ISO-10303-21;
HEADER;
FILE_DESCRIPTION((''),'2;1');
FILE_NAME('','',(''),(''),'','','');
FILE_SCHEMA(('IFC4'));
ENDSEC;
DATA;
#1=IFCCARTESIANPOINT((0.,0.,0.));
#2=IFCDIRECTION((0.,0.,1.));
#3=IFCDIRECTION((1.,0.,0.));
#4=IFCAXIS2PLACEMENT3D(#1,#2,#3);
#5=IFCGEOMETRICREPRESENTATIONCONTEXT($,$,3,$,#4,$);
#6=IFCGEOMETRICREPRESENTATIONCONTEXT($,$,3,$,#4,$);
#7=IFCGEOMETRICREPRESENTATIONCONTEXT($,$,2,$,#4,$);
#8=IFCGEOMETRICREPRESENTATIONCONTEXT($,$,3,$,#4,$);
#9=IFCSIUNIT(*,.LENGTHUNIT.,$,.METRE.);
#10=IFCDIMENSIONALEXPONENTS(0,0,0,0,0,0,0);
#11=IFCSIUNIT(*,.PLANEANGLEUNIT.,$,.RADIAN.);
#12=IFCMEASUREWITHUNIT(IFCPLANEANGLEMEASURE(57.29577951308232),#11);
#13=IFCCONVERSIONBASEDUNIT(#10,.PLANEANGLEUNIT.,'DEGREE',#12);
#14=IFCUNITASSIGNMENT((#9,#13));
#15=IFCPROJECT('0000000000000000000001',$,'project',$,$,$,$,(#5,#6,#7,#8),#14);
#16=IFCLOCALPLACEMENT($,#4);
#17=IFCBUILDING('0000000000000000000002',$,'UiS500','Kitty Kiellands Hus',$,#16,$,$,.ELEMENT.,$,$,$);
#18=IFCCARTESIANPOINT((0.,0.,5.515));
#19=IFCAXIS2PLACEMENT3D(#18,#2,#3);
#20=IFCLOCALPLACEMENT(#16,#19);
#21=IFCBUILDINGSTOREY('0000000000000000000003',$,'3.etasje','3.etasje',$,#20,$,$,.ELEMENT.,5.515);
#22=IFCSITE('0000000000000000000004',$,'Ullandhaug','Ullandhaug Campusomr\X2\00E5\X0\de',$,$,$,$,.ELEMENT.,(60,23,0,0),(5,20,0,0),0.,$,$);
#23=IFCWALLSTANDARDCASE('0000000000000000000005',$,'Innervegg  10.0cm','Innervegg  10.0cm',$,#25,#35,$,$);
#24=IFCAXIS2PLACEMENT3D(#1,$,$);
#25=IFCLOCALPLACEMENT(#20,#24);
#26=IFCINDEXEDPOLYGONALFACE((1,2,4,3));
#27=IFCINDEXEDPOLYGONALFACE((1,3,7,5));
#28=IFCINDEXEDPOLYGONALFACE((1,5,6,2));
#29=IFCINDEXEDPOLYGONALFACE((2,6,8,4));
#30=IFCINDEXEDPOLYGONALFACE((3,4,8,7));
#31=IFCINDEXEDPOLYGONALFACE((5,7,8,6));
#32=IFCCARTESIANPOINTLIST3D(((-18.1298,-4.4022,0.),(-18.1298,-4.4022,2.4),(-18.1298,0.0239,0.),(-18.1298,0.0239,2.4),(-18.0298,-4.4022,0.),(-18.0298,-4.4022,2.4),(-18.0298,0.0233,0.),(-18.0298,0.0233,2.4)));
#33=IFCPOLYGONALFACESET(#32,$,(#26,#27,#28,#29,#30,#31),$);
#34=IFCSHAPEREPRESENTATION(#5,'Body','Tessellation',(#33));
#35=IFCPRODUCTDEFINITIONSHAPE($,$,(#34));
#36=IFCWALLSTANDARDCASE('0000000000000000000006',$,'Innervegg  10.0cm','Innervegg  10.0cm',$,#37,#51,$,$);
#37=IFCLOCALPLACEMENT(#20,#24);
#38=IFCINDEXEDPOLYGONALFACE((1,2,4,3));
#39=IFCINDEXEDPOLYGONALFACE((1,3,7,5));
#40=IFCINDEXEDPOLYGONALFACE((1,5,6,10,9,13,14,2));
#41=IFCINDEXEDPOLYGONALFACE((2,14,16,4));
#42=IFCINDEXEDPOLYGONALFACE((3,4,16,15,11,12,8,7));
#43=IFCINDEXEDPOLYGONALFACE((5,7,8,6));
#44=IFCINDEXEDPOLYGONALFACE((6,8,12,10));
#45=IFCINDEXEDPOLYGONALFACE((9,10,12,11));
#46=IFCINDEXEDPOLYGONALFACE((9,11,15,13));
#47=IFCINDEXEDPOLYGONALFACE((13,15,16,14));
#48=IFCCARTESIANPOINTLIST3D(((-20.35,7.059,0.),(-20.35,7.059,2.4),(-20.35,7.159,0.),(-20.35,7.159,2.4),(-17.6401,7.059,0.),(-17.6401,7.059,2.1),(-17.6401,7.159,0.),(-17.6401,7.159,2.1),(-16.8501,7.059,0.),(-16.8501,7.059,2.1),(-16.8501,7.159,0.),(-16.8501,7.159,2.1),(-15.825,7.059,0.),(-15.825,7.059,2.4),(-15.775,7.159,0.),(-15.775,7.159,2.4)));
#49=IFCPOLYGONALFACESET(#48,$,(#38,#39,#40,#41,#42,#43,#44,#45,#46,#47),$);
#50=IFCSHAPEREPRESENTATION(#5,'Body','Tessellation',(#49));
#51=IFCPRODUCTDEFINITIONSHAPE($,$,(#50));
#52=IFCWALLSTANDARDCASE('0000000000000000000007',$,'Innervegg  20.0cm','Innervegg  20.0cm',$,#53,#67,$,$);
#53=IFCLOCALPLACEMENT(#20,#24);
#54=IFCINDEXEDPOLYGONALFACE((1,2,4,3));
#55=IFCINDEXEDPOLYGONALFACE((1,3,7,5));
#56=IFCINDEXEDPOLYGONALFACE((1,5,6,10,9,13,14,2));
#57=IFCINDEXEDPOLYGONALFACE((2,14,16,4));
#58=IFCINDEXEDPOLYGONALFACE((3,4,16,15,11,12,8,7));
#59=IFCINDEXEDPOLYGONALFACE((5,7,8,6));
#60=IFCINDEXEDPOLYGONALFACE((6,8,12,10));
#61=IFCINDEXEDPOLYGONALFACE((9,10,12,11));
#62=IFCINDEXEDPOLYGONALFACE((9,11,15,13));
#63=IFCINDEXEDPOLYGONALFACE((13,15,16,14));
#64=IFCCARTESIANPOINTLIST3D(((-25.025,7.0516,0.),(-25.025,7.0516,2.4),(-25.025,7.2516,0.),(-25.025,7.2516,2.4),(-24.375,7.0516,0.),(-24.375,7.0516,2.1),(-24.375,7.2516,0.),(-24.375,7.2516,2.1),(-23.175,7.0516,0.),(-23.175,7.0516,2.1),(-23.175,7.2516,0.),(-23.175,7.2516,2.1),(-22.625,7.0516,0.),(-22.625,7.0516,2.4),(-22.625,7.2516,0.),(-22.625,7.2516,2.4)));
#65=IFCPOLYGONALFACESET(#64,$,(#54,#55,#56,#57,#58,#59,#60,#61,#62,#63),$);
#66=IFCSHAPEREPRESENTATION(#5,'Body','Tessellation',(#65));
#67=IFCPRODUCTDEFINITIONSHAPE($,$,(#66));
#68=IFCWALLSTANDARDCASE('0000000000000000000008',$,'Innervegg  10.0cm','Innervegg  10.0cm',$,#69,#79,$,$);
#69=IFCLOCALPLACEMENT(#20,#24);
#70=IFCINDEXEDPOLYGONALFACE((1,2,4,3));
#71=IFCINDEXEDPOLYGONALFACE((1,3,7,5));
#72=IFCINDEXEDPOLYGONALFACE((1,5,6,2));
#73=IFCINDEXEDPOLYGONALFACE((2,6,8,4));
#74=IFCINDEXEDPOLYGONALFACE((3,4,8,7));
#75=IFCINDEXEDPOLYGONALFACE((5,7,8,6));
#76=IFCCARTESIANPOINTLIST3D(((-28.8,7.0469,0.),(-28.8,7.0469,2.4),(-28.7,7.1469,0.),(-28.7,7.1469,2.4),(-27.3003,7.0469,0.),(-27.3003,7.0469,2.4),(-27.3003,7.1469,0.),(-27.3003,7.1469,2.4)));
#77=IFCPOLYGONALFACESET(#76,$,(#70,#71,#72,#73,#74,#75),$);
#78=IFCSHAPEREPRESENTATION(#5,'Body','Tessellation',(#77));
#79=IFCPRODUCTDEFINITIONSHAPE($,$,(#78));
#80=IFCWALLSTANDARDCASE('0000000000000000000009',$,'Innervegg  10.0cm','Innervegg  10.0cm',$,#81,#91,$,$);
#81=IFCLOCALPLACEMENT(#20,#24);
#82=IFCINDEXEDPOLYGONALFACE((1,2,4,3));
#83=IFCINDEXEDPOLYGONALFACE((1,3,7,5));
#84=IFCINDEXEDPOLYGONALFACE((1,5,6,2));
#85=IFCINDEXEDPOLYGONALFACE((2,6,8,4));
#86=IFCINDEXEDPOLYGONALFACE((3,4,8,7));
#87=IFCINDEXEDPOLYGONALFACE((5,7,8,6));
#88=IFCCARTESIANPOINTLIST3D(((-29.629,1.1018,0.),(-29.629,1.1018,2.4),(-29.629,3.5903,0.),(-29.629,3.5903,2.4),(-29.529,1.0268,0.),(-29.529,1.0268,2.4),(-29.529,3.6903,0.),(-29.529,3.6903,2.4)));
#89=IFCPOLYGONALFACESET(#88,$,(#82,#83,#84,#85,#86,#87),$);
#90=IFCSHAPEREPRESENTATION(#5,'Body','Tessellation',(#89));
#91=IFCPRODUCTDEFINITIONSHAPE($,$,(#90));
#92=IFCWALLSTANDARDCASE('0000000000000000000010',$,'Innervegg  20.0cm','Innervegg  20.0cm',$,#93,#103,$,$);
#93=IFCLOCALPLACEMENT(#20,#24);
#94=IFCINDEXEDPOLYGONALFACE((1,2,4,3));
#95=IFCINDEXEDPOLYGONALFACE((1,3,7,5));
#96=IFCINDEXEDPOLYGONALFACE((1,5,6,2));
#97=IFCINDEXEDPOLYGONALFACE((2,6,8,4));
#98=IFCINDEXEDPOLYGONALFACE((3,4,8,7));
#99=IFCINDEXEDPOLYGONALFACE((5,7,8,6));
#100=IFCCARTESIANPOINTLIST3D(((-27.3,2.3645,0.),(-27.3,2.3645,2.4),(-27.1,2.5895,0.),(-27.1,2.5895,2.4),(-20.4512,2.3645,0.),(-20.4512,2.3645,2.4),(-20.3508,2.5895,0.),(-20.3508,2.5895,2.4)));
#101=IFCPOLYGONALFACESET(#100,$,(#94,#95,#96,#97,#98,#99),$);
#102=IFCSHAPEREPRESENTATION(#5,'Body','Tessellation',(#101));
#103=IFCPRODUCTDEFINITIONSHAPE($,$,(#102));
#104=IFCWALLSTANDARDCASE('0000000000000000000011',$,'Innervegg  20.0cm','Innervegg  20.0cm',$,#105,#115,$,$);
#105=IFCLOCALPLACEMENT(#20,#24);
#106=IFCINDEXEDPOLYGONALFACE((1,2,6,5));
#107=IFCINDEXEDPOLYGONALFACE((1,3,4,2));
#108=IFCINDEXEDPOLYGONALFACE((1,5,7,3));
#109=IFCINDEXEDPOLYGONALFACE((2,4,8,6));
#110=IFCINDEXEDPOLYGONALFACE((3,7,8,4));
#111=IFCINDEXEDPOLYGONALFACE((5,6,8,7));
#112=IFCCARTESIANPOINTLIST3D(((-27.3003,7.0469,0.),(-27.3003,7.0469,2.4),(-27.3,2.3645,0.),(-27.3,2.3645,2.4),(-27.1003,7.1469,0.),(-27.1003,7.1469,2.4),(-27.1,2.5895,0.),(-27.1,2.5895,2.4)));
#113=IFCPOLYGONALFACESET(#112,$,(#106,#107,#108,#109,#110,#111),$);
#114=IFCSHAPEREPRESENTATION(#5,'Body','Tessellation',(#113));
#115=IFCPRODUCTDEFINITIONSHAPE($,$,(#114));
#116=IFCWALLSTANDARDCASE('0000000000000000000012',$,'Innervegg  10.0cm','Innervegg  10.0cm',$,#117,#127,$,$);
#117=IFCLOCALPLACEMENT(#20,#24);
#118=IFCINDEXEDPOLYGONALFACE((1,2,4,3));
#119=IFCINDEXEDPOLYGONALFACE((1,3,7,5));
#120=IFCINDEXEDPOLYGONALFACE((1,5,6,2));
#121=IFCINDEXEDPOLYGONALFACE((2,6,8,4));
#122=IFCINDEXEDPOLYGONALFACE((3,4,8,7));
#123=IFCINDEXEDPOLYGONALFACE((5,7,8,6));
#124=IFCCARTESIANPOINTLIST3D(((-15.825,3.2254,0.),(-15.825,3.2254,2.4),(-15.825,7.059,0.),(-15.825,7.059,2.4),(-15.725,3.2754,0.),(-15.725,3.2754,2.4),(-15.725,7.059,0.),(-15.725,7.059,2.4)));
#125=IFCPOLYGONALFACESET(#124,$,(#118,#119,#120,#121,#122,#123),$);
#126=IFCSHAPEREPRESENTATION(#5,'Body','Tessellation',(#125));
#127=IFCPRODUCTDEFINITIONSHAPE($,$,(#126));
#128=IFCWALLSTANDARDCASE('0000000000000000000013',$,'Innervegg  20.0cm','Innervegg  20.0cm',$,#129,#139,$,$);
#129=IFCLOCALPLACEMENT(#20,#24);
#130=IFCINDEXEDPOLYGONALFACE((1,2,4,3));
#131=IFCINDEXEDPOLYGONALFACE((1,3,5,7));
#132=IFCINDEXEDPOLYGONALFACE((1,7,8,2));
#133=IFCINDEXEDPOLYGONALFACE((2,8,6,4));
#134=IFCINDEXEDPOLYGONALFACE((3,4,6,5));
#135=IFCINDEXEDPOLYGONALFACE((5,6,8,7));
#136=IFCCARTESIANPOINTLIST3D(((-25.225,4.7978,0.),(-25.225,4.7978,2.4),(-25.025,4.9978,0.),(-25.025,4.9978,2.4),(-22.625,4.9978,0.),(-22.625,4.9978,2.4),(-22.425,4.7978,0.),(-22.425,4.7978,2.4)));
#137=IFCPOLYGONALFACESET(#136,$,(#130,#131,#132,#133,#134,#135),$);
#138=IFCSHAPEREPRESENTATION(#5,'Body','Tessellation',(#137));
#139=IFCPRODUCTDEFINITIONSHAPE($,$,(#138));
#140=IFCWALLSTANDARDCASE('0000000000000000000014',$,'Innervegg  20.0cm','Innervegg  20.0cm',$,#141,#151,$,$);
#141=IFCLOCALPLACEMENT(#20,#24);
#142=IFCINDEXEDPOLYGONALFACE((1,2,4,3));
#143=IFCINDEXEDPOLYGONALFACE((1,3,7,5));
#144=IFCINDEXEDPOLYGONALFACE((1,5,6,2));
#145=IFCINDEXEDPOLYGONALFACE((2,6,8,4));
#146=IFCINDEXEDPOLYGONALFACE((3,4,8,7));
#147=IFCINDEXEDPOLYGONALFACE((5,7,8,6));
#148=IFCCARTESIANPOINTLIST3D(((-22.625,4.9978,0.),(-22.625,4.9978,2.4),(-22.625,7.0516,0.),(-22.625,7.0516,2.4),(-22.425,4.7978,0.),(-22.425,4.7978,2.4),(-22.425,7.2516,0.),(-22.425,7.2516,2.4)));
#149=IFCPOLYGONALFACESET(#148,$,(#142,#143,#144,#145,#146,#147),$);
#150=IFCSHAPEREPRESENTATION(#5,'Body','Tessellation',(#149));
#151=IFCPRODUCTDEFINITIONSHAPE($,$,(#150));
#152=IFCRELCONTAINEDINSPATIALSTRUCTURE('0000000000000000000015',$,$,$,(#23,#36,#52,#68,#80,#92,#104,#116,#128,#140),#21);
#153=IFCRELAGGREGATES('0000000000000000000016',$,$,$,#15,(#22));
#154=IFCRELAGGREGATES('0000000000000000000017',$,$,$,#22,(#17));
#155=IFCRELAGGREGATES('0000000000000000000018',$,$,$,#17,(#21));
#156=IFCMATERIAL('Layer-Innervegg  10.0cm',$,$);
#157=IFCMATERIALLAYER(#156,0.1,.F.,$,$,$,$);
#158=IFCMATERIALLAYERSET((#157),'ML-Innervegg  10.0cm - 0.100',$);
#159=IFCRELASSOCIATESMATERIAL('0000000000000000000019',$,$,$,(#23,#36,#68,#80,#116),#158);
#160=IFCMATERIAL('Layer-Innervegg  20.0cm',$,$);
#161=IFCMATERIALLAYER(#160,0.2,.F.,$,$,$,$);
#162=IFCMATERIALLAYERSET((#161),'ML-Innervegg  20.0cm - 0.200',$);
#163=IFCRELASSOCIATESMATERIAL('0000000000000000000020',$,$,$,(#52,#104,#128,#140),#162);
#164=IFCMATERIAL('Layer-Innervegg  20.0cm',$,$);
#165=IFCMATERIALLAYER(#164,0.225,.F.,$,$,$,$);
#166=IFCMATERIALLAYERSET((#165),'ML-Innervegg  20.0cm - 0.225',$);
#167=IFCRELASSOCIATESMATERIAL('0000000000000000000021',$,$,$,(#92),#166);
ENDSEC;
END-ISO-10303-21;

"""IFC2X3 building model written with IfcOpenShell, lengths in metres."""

from ifc_helpers import new_model, entity, si_unit, converted_unit, frame, origin_with_axes, place, context, project, spatial, polyline, outline, extrude, material, layer, layer_set, layer_usage, element, save


model = new_model("IFC2X3")

# Units and contexts
context_of_model_1 = context(None, 3, world=origin_with_axes())
context_of_model_2 = context(None, 3, world=origin_with_axes())
context_of_model_3 = context(None, 2, world=origin_with_axes())
context_of_model_4 = context(None, 3, world=origin_with_axes())
ifc_project = project(units=[si_unit("LENGTHUNIT", "METRE"), converted_unit("PLANEANGLEUNIT", "DEGREE", entity("IfcPlaneAngleMeasure", 57.29577951308232), si_unit("PLANEANGLEUNIT", "RADIAN"), dimensions=[0, 0, 0, 0, 0, 0, 0])], contexts=[context_of_model_1, context_of_model_2, context_of_model_3, context_of_model_4])

# Site, building, storey
site = spatial("IfcSite", under=ifc_project, Name="Ullandhaug", Description="Ullandhaug Campusområde", CompositionType="ELEMENT", RefLatitude=(60, 23, 0, 0), RefLongitude=(5, 20, 0, 0), RefElevation=0.0)
building_placement = place(None, origin_with_axes())
building = spatial("IfcBuilding", under=site, at=building_placement, Name="UiS500", Description="Kitty Kiellands Hus", CompositionType="ELEMENT")
storey_placement = place(building_placement, frame((0.0, 0.0, 5.515), z_axis=(0.0, 0.0, 1.0), x_axis=(1.0, 0.0, 0.0)))
storey = spatial("IfcBuildingStorey", under=building, at=storey_placement, Name="3.etasje", Description="3.etasje", CompositionType="ELEMENT", Elevation=5.515)

# Shared definitions
ifc_material_1 = material(Name="Layer-Innervegg  10.0cm")
ifc_layer_1 = layer(ifc_material_1, 0.1, ventilated=False)
ifc_layer_set_1 = layer_set([ifc_layer_1], Name="ML-Innervegg  10.0cm - 0.100")
ifc_layer_usage_1 = layer_usage(ifc_layer_set_1, "AXIS2", "POSITIVE", 0.0)

# Wall
wall_1_placement = place(storey_placement, frame((-18.1298, 0.0239, 0.0), z_axis=(0.0, 0.0, 1.0), x_axis=(0.0, -1.0, 0.0)))
element("IfcWallStandardCase", 1, at=wall_1_placement, inside=storey, material=ifc_layer_usage_1, Name="Innervegg  10.0cm", Description="Innervegg  10.0cm", context=context_of_model_1, shape_type="SweptSolid", body=[
    extrude(outline(polyline([(0.0, 0.0), (4.4262, 0.0), (4.4262, 0.1), (0.0006, 0.1), (0.0, 0.0)])), frame((0.0, 0.0, 0.0), z_axis=(0.0, 0.0, 1.0), x_axis=(1.0, 0.0, 0.0)), (0.0, 0.0, 1.0), 2.4),
])

# Walls, openings
wall_2_placement = place(storey_placement, frame((-20.35, 7.059, 0.0), z_axis=(0.0, 0.0, 1.0), x_axis=(1.0, 0.0, 0.0)))
wall_2 = element("IfcWallStandardCase", 2, at=wall_2_placement, inside=storey, material=ifc_layer_usage_1, Name="Innervegg  10.0cm", Description="Innervegg  10.0cm", context=context_of_model_1, shape_type="SweptSolid", body=[
    extrude(outline(polyline([(0.0, 0.0), (4.525, 0.0), (4.575, 0.1), (0.0, 0.1), (0.0, 0.0)])), origin_with_axes(), (0.0, 0.0, 1.0), 2.4),
])
opening_1_placement = place(wall_2_placement, frame((2.7099, 0.1, 0.0), z_axis=(0.0, 0.0, 1.0), x_axis=(1.0, 0.0, 0.0)))
element("IfcOpeningElement", 3, at=opening_1_placement, cuts=wall_2, context=context_of_model_1, shape_type="SweptSolid", body=[
    extrude(outline(polyline([(0.0, 0.0), (2.1, 0.0), (2.1, 0.79), (0.0, 0.79), (0.0, 0.0)])), frame((0.0, 0.0, 0.0), z_axis=(0.0, 1.0, 0.0), x_axis=(0.0, 0.0, 1.0)), (0.0, 0.0, -1.0), 0.1),
])
ifc_material_2 = material(Name="Layer-Innervegg  20.0cm")
ifc_layer_2 = layer(ifc_material_2, 0.2, ventilated=False)
ifc_layer_set_2 = layer_set([ifc_layer_2], Name="ML-Innervegg  20.0cm - 0.200")
ifc_layer_usage_2 = layer_usage(ifc_layer_set_2, "AXIS2", "POSITIVE", 0.0)
wall_3_placement = place(storey_placement, frame((-25.025, 7.0516, 0.0), z_axis=(0.0, 0.0, 1.0), x_axis=(1.0, 0.0, 0.0)))
wall_3 = element("IfcWallStandardCase", 4, at=wall_3_placement, inside=storey, material=ifc_layer_usage_2, Name="Innervegg  20.0cm", Description="Innervegg  20.0cm", context=context_of_model_1, shape_type="SweptSolid", body=[
    extrude(outline(polyline([(0.0, 0.0), (2.4, 0.0), (2.4, 0.2), (0.0, 0.2), (0.0, 0.0)])), origin_with_axes(), (0.0, 0.0, 1.0), 2.4),
])
opening_2_placement = place(wall_3_placement, frame((0.65, 0.2, 0.0), z_axis=(0.0, 0.0, 1.0), x_axis=(1.0, 0.0, 0.0)))
element("IfcOpeningElement", 5, at=opening_2_placement, cuts=wall_3, context=context_of_model_1, shape_type="SweptSolid", body=[
    extrude(outline(polyline([(0.0, 0.0), (2.1, 0.0), (2.1, 1.2), (0.0, 1.2), (0.0, 0.0)])), frame((0.0, 0.0, 0.0), z_axis=(0.0, 1.0, 0.0), x_axis=(0.0, 0.0, 1.0)), (0.0, 0.0, -1.0), 0.2),
])

# Walls
wall_4_placement = place(storey_placement, frame((-28.8, 7.0469, 0.0), z_axis=(0.0, 0.0, 1.0), x_axis=(1.0, 0.0, 0.0)))
element("IfcWallStandardCase", 6, at=wall_4_placement, inside=storey, material=ifc_layer_usage_1, Name="Innervegg  10.0cm", Description="Innervegg  10.0cm", context=context_of_model_1, shape_type="SweptSolid", body=[
    extrude(outline(polyline([(0.0, 0.0), (1.4997, 0.0), (1.4997, 0.1), (0.1, 0.1), (0.0, 0.0)])), origin_with_axes(), (0.0, 0.0, 1.0), 2.4),
])
wall_5_placement = place(storey_placement, frame((-29.629, 3.5903, 0.0), z_axis=(0.0, 0.0, 1.0), x_axis=(0.0, -1.0, 0.0)))
element("IfcWallStandardCase", 7, at=wall_5_placement, inside=storey, material=ifc_layer_usage_1, Name="Innervegg  10.0cm", Description="Innervegg  10.0cm", context=context_of_model_1, shape_type="SweptSolid", body=[
    extrude(outline(polyline([(0.0, 0.0), (2.4885, 0.0), (2.5635, 0.1), (-0.1, 0.1), (0.0, 0.0)])), frame((0.0, 0.0, 0.0), z_axis=(0.0, 0.0, 1.0), x_axis=(1.0, 0.0, 0.0)), (0.0, 0.0, 1.0), 2.4),
])
ifc_material_3 = material(Name="Layer-Innervegg  20.0cm")
ifc_layer_3 = layer(ifc_material_3, 0.225, ventilated=False)
ifc_layer_set_3 = layer_set([ifc_layer_3], Name="ML-Innervegg  20.0cm - 0.225")
ifc_layer_usage_3 = layer_usage(ifc_layer_set_3, "AXIS2", "POSITIVE", 0.0)
wall_6_placement = place(storey_placement, frame((-20.3508, 2.5895, 0.0), z_axis=(0.0, 0.0, 1.0), x_axis=(-1.0, 0.0, 0.0)))
element("IfcWallStandardCase", 8, at=wall_6_placement, inside=storey, material=ifc_layer_usage_3, Name="Innervegg  20.0cm", Description="Innervegg  20.0cm", context=context_of_model_1, shape_type="SweptSolid", body=[
    extrude(outline(polyline([(0.0, 0.0), (6.7492, 0.0), (6.9492, 0.225), (0.1004, 0.225), (0.0, 0.0)])), frame((0.0, 0.0, 0.0), z_axis=(0.0, 0.0, 1.0), x_axis=(1.0, 0.0, 0.0)), (0.0, 0.0, 1.0), 2.4),
])
wall_7_placement = place(storey_placement, frame((-27.1, 2.5895, 0.0), z_axis=(0.0, 0.0, 1.0), x_axis=(-0.000054, 1.0, 0.0)))
element("IfcWallStandardCase", 9, at=wall_7_placement, inside=storey, material=ifc_layer_usage_2, Name="Innervegg  20.0cm", Description="Innervegg  20.0cm", context=context_of_model_1, shape_type="SweptSolid", body=[
    extrude(outline(polyline([(0.0, 0.0), (4.5574, 0.0), (4.4574, 0.2), (-0.225, 0.2), (0.0, 0.0)])), frame((0.0, 0.0, 0.0), z_axis=(0.0, 0.0, 1.0), x_axis=(1.0, 0.0, 0.0)), (0.0, 0.0, 1.0), 2.4),
])
wall_8_placement = place(storey_placement, frame((-15.825, 7.059, 0.0), z_axis=(0.0, 0.0, 1.0), x_axis=(0.0, -1.0, 0.0)))
element("IfcWallStandardCase", 10, at=wall_8_placement, inside=storey, material=ifc_layer_usage_1, Name="Innervegg  10.0cm", Description="Innervegg  10.0cm", context=context_of_model_1, shape_type="SweptSolid", body=[
    extrude(outline(polyline([(0.0, 0.0), (3.8336, 0.0), (3.7836, 0.1), (0.0, 0.1), (0.0, 0.0)])), frame((0.0, 0.0, 0.0), z_axis=(0.0, 0.0, 1.0), x_axis=(1.0, 0.0, 0.0)), (0.0, 0.0, 1.0), 2.4),
])
wall_9_placement = place(storey_placement, frame((-25.225, 4.7978, 0.0), z_axis=(0.0, 0.0, 1.0), x_axis=(1.0, 0.0, 0.0)))
element("IfcWallStandardCase", 11, at=wall_9_placement, inside=storey, material=ifc_layer_usage_2, Name="Innervegg  20.0cm", Description="Innervegg  20.0cm", context=context_of_model_1, shape_type="SweptSolid", body=[
    extrude(outline(polyline([(0.0, 0.0), (2.8, 0.0), (2.6, 0.2), (0.2, 0.2), (0.0, 0.0)])), origin_with_axes(), (0.0, 0.0, 1.0), 2.4),
])
wall_10_placement = place(storey_placement, frame((-22.425, 4.7978, 0.0), z_axis=(0.0, 0.0, 1.0), x_axis=(0.0, 1.0, 0.0)))
element("IfcWallStandardCase", 12, at=wall_10_placement, inside=storey, material=ifc_layer_usage_2, Name="Innervegg  20.0cm", Description="Innervegg  20.0cm", context=context_of_model_1, shape_type="SweptSolid", body=[
    extrude(outline(polyline([(0.0, 0.0), (2.4539, 0.0), (2.2539, 0.2), (0.2, 0.2), (0.0, 0.0)])), frame((0.0, 0.0, 0.0), z_axis=(0.0, 0.0, 1.0), x_axis=(1.0, 0.0, 0.0)), (0.0, 0.0, 1.0), 2.4),
])

save(model, "model.ifc")
